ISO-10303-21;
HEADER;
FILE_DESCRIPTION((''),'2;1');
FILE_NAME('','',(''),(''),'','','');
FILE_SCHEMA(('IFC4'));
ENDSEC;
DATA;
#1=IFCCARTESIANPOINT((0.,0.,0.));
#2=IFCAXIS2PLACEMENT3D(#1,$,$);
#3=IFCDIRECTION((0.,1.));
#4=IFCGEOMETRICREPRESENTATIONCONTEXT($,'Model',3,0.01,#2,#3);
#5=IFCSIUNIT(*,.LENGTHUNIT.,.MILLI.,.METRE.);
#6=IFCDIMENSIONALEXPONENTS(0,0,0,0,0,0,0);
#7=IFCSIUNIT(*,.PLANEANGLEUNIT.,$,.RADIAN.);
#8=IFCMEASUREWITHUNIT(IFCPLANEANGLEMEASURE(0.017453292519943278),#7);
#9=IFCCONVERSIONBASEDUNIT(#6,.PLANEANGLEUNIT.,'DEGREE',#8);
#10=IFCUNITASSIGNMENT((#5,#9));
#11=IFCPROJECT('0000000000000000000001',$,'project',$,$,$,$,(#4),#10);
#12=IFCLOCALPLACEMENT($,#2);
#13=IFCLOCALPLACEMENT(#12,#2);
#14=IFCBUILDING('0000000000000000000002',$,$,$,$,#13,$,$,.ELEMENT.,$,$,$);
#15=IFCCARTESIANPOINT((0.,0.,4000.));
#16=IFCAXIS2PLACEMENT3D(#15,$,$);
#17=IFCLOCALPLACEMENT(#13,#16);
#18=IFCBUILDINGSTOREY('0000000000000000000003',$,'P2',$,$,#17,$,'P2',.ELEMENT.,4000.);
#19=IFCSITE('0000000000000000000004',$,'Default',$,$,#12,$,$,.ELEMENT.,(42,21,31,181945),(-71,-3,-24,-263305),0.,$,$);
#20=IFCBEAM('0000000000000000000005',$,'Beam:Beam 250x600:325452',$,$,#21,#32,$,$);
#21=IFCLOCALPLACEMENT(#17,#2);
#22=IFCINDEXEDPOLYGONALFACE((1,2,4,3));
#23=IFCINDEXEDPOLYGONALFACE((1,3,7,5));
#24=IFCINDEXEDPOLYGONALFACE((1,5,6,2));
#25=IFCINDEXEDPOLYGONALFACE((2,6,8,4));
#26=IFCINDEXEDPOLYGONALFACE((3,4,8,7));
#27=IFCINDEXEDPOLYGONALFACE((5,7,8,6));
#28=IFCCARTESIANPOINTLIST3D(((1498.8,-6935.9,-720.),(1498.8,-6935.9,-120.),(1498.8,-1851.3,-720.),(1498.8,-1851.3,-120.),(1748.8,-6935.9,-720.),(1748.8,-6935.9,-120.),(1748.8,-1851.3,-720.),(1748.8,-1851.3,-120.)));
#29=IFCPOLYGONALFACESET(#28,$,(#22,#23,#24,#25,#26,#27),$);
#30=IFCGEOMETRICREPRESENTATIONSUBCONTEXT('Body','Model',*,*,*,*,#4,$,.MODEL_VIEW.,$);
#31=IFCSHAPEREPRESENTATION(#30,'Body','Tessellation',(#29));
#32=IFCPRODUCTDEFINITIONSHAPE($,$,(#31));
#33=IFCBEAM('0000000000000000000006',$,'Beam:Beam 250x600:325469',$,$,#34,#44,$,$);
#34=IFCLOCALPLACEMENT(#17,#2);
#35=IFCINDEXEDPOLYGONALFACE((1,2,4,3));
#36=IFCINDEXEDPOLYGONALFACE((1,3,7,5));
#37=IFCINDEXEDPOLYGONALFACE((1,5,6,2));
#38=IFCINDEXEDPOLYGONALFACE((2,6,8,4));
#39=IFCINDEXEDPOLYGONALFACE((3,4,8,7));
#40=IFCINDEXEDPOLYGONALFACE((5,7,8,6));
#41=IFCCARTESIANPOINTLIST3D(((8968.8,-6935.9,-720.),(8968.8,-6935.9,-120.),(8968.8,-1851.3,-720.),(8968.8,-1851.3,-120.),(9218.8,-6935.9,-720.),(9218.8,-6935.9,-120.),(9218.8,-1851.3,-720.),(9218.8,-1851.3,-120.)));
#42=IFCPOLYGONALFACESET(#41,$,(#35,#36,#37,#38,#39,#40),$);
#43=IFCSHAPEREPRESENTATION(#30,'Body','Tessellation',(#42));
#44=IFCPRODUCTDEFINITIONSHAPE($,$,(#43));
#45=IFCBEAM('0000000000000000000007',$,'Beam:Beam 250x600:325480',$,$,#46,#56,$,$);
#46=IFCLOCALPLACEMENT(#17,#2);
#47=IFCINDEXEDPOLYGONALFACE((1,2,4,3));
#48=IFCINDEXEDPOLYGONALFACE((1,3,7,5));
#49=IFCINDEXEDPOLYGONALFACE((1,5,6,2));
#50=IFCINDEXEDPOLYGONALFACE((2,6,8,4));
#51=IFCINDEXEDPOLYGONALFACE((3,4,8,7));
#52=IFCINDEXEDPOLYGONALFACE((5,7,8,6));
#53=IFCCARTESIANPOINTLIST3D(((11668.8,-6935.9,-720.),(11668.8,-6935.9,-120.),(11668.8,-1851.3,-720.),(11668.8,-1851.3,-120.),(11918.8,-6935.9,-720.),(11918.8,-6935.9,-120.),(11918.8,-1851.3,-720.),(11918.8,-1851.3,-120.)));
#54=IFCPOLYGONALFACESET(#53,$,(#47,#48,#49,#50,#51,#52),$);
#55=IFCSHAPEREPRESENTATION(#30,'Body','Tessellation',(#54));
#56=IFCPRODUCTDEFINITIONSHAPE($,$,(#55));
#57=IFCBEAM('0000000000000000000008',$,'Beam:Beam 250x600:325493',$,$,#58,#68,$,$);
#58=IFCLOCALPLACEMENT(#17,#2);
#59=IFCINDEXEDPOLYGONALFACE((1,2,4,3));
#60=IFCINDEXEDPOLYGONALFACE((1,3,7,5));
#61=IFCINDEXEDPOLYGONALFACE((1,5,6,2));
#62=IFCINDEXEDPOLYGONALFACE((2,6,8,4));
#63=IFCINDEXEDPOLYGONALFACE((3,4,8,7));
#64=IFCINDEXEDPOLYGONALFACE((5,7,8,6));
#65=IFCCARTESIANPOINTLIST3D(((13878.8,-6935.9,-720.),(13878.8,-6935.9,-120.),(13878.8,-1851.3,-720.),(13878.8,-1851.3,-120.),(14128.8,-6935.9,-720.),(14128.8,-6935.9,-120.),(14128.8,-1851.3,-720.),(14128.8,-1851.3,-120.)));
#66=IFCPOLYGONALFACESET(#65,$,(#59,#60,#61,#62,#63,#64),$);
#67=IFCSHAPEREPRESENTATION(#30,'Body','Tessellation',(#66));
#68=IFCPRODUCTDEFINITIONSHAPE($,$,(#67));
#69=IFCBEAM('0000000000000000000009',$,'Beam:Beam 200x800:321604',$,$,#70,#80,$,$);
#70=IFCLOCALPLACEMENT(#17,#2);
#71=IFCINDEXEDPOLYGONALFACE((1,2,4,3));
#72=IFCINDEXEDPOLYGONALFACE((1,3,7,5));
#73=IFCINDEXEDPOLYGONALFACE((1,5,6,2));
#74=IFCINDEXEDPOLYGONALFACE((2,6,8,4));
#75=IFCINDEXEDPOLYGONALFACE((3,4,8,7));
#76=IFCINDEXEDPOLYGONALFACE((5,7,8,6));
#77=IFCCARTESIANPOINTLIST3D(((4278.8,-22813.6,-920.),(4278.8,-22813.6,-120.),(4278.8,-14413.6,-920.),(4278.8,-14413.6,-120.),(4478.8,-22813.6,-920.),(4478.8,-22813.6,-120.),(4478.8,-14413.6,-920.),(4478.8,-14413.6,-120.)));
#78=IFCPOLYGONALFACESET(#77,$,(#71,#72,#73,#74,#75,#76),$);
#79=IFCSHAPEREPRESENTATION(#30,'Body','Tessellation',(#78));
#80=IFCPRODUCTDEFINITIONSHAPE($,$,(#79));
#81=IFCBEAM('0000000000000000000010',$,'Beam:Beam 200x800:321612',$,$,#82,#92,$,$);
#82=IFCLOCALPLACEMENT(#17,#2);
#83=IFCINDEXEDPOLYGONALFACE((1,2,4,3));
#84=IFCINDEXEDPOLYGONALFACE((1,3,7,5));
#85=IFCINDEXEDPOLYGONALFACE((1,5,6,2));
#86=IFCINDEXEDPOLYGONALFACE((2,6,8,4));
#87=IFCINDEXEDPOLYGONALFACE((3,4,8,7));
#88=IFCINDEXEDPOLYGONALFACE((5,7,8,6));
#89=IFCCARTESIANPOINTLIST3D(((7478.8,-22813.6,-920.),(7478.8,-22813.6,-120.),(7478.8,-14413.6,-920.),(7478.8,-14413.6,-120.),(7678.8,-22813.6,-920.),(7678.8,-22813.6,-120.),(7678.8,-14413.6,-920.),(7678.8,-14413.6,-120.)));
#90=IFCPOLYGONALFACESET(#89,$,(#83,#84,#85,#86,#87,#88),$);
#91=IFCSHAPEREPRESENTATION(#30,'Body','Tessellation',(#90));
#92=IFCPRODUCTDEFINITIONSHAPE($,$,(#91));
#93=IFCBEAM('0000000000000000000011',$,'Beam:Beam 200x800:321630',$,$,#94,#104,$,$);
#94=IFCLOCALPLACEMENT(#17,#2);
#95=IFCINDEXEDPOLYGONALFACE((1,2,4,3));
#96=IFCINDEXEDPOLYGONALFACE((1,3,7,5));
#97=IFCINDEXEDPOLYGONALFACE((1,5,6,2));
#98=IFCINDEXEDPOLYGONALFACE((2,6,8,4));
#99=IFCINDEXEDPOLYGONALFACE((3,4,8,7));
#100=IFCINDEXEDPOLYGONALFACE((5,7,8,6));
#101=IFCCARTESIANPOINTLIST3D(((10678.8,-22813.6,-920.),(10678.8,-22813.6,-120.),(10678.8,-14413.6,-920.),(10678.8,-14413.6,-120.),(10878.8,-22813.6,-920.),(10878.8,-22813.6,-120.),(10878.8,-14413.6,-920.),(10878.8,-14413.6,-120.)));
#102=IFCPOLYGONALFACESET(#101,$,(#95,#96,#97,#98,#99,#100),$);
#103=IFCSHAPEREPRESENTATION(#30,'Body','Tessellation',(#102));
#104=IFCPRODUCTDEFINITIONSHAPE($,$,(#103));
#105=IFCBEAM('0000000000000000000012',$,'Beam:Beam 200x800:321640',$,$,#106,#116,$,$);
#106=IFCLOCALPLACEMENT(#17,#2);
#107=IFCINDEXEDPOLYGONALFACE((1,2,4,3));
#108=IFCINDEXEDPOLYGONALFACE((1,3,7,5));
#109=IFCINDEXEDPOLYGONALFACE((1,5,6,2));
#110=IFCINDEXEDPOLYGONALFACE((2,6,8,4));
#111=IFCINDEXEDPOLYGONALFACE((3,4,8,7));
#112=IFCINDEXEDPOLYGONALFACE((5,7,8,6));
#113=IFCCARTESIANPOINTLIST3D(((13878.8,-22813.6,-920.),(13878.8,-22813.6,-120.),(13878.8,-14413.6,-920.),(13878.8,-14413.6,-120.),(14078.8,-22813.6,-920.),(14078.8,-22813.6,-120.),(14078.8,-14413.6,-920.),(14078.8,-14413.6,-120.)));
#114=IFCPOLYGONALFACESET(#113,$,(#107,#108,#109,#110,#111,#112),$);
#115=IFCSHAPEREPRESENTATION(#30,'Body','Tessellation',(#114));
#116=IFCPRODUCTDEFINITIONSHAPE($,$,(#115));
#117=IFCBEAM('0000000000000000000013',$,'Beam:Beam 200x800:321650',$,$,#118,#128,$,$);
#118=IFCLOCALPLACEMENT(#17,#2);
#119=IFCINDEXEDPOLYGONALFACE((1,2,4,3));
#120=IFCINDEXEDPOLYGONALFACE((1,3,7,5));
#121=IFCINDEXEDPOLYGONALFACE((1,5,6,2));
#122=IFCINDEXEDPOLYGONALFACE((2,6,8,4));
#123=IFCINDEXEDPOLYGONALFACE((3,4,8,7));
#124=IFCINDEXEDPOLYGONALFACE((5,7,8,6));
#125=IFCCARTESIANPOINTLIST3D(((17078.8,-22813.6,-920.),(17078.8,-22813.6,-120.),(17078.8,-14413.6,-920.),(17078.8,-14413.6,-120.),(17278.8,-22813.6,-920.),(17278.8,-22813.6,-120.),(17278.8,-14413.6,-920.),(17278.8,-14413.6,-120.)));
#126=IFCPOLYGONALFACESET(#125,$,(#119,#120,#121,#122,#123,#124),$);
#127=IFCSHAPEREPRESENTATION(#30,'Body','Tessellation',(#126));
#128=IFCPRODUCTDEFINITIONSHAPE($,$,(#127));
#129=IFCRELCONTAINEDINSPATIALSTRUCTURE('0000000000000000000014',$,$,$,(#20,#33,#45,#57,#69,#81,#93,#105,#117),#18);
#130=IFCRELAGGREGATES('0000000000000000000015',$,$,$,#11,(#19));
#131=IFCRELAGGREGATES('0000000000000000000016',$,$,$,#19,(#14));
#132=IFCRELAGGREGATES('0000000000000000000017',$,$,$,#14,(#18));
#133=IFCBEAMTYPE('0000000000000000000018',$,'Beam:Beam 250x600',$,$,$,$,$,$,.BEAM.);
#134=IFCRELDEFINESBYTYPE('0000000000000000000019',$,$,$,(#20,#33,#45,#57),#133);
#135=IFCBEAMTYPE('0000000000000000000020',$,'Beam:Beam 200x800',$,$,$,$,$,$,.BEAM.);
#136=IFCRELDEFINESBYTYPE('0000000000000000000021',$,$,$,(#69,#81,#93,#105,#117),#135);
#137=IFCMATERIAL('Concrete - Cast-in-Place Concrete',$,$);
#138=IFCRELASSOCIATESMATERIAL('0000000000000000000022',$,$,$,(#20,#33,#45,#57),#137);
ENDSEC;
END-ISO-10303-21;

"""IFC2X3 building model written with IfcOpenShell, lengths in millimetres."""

from ifc_helpers import new_model, entity, si_unit, converted_unit, direction, frame, frame_2d, origin, origin_2d_with_axis, place, context, subcontext, project, spatial, rectangle, extrude, material, type_object, element, save


model = new_model("IFC2X3")

# Units and contexts
model_context = context("Model", 3, precision=0.01, world=origin(), true_north=direction((0.0, 1.0)))
body_context = subcontext(model_context, "Body", "Model", "MODEL_VIEW")
ifc_project = project(units=[si_unit("LENGTHUNIT", "METRE", prefix="MILLI"), converted_unit("PLANEANGLEUNIT", "DEGREE", entity("IfcPlaneAngleMeasure", 0.017453292519943278), si_unit("PLANEANGLEUNIT", "RADIAN"), dimensions=[0, 0, 0, 0, 0, 0, 0])], contexts=[model_context])

# Site, building, storey
site_placement = place(None, origin())
site = spatial("IfcSite", under=ifc_project, at=site_placement, Name="Default", CompositionType="ELEMENT", RefLatitude=(42, 21, 31, 181945), RefLongitude=(-71, -3, -24, -263305), RefElevation=0.0)
building_placement = place(site_placement, origin())
building = spatial("IfcBuilding", under=site, at=building_placement, CompositionType="ELEMENT")
storey_placement = place(building_placement, frame((0.0, 0.0, 4000.0)))
storey = spatial("IfcBuildingStorey", under=building, at=storey_placement, Name="P2", LongName="P2", CompositionType="ELEMENT", Elevation=4000.0)

# Beams
ifc_material_1 = material(Name="Concrete - Cast-in-Place Concrete")
beam_type_1 = type_object("IfcBeamType", Name="Beam:Beam 250x600", PredefinedType="BEAM")
beam_1_placement = place(storey_placement, frame((1623.8, -6978.6, -120.0), z_axis=(0.0, 0.0, 1.0), x_axis=(0.0, 1.0, 0.0)))
element("IfcBeam", 1, at=beam_1_placement, inside=storey, type_object=beam_type_1, material=ifc_material_1, Name="Beam:Beam 250x600:325452", context=body_context, shape_type="SweptSolid", body=[
    extrude(rectangle(XDim=600.0, YDim=250.0, at=frame_2d((0.0, 0.0), x_axis=(1.0, 0.0))), frame((42.7, 0.0, -300.0), z_axis=(1.0, 0.0, 0.0), x_axis=(0.0, 0.0, -1.0)), (0.0, 0.0, 1.0), 5084.6),
])
for number, where, z_axis, x_axis, name in (
    (2, (9093.8, -6978.6, -120.0), (0.0, 0.0, 1.0), (0.0, 1.0, 0.0), "Beam:Beam 250x600:325469"),
    (3, (11793.8, -6978.6, -120.0), (0.0, 0.0, 1.0), (0.0, 1.0, 0.0), "Beam:Beam 250x600:325480"),
):
    element("IfcBeam", number, at=place(storey_placement, frame(where, z_axis=z_axis, x_axis=x_axis)), inside=storey, type_object=beam_type_1, material=ifc_material_1, Name=name, context=body_context, shape_type="SweptSolid", body=[
        extrude(rectangle(XDim=600.0, YDim=250.0, at=frame_2d((0.0, 0.0), x_axis=(1.0, 0.0))), frame((42.7, 0.0, -300.0), z_axis=(1.0, 0.0, 0.0), x_axis=(0.0, 0.0, -1.0)), (0.0, 0.0, 1.0), 5084.6),
    ])
beam_2_placement = place(storey_placement, frame((14003.8, -6978.6, -120.0), z_axis=(0.0, 0.0, 1.0), x_axis=(0.0, 1.0, 0.0)))
element("IfcBeam", 4, at=beam_2_placement, inside=storey, type_object=beam_type_1, material=ifc_material_1, Name="Beam:Beam 250x600:325493", context=body_context, shape_type="SweptSolid", body=[
    extrude(rectangle(XDim=600.0, YDim=250.0, at=frame_2d((0.0, 0.0), x_axis=(1.0, 0.0))), frame((42.7, 0.0, -300.0), z_axis=(1.0, 0.0, 0.0), x_axis=(0.0, 0.0, -1.0)), (0.0, 0.0, 1.0), 5084.6),
])
beam_type_2 = type_object("IfcBeamType", Name="Beam:Beam 200x800", PredefinedType="BEAM")
beam_3_placement = place(storey_placement, frame((4353.8, -14413.6, -120.0), z_axis=(0.0, 0.0, 1.0), x_axis=(0.0, -1.0, 0.0)))
element("IfcBeam", 5, at=beam_3_placement, inside=storey, type_object=beam_type_2, Name="Beam:Beam 200x800:321604", context=body_context, shape_type="SweptSolid", body=[
    extrude(rectangle(XDim=800.0, YDim=200.0, at=origin_2d_with_axis()), frame((0.0, 25.0, -400.0), z_axis=(1.0, 0.0, 0.0), x_axis=(0.0, 0.0, -1.0)), (0.0, 0.0, 1.0), 8400.0),
])
beam_4_placement = place(storey_placement, frame((7553.8, -14413.6, -120.0), z_axis=(0.0, 0.0, 1.0), x_axis=(0.0, -1.0, 0.0)))
element("IfcBeam", 6, at=beam_4_placement, inside=storey, type_object=beam_type_2, Name="Beam:Beam 200x800:321612", context=body_context, shape_type="SweptSolid", body=[
    extrude(rectangle(XDim=800.0, YDim=200.0, at=origin_2d_with_axis()), frame((0.0, 25.0, -400.0), z_axis=(1.0, 0.0, 0.0), x_axis=(0.0, 0.0, -1.0)), (0.0, 0.0, 1.0), 8400.0),
])
for number, where, z_axis, x_axis, name in (
    (7, (10753.8, -14413.6, -120.0), (0.0, 0.0, 1.0), (0.0, -1.0, 0.0), "Beam:Beam 200x800:321630"),
    (8, (13953.8, -14413.6, -120.0), (0.0, 0.0, 1.0), (0.0, -1.0, 0.0), "Beam:Beam 200x800:321640"),
    (9, (17153.8, -14413.6, -120.0), (0.0, 0.0, 1.0), (0.0, -1.0, 0.0), "Beam:Beam 200x800:321650"),
):
    element("IfcBeam", number, at=place(storey_placement, frame(where, z_axis=z_axis, x_axis=x_axis)), inside=storey, type_object=beam_type_2, Name=name, context=body_context, shape_type="SweptSolid", body=[
        extrude(rectangle(XDim=800.0, YDim=200.0, at=frame_2d((0.0, 0.0), x_axis=(1.0, 0.0))), frame((0.0, 25.0, -400.0), z_axis=(1.0, 0.0, 0.0), x_axis=(0.0, 0.0, -1.0)), (0.0, 0.0, 1.0), 8400.0),
    ])

save(model, "model.ifc")
